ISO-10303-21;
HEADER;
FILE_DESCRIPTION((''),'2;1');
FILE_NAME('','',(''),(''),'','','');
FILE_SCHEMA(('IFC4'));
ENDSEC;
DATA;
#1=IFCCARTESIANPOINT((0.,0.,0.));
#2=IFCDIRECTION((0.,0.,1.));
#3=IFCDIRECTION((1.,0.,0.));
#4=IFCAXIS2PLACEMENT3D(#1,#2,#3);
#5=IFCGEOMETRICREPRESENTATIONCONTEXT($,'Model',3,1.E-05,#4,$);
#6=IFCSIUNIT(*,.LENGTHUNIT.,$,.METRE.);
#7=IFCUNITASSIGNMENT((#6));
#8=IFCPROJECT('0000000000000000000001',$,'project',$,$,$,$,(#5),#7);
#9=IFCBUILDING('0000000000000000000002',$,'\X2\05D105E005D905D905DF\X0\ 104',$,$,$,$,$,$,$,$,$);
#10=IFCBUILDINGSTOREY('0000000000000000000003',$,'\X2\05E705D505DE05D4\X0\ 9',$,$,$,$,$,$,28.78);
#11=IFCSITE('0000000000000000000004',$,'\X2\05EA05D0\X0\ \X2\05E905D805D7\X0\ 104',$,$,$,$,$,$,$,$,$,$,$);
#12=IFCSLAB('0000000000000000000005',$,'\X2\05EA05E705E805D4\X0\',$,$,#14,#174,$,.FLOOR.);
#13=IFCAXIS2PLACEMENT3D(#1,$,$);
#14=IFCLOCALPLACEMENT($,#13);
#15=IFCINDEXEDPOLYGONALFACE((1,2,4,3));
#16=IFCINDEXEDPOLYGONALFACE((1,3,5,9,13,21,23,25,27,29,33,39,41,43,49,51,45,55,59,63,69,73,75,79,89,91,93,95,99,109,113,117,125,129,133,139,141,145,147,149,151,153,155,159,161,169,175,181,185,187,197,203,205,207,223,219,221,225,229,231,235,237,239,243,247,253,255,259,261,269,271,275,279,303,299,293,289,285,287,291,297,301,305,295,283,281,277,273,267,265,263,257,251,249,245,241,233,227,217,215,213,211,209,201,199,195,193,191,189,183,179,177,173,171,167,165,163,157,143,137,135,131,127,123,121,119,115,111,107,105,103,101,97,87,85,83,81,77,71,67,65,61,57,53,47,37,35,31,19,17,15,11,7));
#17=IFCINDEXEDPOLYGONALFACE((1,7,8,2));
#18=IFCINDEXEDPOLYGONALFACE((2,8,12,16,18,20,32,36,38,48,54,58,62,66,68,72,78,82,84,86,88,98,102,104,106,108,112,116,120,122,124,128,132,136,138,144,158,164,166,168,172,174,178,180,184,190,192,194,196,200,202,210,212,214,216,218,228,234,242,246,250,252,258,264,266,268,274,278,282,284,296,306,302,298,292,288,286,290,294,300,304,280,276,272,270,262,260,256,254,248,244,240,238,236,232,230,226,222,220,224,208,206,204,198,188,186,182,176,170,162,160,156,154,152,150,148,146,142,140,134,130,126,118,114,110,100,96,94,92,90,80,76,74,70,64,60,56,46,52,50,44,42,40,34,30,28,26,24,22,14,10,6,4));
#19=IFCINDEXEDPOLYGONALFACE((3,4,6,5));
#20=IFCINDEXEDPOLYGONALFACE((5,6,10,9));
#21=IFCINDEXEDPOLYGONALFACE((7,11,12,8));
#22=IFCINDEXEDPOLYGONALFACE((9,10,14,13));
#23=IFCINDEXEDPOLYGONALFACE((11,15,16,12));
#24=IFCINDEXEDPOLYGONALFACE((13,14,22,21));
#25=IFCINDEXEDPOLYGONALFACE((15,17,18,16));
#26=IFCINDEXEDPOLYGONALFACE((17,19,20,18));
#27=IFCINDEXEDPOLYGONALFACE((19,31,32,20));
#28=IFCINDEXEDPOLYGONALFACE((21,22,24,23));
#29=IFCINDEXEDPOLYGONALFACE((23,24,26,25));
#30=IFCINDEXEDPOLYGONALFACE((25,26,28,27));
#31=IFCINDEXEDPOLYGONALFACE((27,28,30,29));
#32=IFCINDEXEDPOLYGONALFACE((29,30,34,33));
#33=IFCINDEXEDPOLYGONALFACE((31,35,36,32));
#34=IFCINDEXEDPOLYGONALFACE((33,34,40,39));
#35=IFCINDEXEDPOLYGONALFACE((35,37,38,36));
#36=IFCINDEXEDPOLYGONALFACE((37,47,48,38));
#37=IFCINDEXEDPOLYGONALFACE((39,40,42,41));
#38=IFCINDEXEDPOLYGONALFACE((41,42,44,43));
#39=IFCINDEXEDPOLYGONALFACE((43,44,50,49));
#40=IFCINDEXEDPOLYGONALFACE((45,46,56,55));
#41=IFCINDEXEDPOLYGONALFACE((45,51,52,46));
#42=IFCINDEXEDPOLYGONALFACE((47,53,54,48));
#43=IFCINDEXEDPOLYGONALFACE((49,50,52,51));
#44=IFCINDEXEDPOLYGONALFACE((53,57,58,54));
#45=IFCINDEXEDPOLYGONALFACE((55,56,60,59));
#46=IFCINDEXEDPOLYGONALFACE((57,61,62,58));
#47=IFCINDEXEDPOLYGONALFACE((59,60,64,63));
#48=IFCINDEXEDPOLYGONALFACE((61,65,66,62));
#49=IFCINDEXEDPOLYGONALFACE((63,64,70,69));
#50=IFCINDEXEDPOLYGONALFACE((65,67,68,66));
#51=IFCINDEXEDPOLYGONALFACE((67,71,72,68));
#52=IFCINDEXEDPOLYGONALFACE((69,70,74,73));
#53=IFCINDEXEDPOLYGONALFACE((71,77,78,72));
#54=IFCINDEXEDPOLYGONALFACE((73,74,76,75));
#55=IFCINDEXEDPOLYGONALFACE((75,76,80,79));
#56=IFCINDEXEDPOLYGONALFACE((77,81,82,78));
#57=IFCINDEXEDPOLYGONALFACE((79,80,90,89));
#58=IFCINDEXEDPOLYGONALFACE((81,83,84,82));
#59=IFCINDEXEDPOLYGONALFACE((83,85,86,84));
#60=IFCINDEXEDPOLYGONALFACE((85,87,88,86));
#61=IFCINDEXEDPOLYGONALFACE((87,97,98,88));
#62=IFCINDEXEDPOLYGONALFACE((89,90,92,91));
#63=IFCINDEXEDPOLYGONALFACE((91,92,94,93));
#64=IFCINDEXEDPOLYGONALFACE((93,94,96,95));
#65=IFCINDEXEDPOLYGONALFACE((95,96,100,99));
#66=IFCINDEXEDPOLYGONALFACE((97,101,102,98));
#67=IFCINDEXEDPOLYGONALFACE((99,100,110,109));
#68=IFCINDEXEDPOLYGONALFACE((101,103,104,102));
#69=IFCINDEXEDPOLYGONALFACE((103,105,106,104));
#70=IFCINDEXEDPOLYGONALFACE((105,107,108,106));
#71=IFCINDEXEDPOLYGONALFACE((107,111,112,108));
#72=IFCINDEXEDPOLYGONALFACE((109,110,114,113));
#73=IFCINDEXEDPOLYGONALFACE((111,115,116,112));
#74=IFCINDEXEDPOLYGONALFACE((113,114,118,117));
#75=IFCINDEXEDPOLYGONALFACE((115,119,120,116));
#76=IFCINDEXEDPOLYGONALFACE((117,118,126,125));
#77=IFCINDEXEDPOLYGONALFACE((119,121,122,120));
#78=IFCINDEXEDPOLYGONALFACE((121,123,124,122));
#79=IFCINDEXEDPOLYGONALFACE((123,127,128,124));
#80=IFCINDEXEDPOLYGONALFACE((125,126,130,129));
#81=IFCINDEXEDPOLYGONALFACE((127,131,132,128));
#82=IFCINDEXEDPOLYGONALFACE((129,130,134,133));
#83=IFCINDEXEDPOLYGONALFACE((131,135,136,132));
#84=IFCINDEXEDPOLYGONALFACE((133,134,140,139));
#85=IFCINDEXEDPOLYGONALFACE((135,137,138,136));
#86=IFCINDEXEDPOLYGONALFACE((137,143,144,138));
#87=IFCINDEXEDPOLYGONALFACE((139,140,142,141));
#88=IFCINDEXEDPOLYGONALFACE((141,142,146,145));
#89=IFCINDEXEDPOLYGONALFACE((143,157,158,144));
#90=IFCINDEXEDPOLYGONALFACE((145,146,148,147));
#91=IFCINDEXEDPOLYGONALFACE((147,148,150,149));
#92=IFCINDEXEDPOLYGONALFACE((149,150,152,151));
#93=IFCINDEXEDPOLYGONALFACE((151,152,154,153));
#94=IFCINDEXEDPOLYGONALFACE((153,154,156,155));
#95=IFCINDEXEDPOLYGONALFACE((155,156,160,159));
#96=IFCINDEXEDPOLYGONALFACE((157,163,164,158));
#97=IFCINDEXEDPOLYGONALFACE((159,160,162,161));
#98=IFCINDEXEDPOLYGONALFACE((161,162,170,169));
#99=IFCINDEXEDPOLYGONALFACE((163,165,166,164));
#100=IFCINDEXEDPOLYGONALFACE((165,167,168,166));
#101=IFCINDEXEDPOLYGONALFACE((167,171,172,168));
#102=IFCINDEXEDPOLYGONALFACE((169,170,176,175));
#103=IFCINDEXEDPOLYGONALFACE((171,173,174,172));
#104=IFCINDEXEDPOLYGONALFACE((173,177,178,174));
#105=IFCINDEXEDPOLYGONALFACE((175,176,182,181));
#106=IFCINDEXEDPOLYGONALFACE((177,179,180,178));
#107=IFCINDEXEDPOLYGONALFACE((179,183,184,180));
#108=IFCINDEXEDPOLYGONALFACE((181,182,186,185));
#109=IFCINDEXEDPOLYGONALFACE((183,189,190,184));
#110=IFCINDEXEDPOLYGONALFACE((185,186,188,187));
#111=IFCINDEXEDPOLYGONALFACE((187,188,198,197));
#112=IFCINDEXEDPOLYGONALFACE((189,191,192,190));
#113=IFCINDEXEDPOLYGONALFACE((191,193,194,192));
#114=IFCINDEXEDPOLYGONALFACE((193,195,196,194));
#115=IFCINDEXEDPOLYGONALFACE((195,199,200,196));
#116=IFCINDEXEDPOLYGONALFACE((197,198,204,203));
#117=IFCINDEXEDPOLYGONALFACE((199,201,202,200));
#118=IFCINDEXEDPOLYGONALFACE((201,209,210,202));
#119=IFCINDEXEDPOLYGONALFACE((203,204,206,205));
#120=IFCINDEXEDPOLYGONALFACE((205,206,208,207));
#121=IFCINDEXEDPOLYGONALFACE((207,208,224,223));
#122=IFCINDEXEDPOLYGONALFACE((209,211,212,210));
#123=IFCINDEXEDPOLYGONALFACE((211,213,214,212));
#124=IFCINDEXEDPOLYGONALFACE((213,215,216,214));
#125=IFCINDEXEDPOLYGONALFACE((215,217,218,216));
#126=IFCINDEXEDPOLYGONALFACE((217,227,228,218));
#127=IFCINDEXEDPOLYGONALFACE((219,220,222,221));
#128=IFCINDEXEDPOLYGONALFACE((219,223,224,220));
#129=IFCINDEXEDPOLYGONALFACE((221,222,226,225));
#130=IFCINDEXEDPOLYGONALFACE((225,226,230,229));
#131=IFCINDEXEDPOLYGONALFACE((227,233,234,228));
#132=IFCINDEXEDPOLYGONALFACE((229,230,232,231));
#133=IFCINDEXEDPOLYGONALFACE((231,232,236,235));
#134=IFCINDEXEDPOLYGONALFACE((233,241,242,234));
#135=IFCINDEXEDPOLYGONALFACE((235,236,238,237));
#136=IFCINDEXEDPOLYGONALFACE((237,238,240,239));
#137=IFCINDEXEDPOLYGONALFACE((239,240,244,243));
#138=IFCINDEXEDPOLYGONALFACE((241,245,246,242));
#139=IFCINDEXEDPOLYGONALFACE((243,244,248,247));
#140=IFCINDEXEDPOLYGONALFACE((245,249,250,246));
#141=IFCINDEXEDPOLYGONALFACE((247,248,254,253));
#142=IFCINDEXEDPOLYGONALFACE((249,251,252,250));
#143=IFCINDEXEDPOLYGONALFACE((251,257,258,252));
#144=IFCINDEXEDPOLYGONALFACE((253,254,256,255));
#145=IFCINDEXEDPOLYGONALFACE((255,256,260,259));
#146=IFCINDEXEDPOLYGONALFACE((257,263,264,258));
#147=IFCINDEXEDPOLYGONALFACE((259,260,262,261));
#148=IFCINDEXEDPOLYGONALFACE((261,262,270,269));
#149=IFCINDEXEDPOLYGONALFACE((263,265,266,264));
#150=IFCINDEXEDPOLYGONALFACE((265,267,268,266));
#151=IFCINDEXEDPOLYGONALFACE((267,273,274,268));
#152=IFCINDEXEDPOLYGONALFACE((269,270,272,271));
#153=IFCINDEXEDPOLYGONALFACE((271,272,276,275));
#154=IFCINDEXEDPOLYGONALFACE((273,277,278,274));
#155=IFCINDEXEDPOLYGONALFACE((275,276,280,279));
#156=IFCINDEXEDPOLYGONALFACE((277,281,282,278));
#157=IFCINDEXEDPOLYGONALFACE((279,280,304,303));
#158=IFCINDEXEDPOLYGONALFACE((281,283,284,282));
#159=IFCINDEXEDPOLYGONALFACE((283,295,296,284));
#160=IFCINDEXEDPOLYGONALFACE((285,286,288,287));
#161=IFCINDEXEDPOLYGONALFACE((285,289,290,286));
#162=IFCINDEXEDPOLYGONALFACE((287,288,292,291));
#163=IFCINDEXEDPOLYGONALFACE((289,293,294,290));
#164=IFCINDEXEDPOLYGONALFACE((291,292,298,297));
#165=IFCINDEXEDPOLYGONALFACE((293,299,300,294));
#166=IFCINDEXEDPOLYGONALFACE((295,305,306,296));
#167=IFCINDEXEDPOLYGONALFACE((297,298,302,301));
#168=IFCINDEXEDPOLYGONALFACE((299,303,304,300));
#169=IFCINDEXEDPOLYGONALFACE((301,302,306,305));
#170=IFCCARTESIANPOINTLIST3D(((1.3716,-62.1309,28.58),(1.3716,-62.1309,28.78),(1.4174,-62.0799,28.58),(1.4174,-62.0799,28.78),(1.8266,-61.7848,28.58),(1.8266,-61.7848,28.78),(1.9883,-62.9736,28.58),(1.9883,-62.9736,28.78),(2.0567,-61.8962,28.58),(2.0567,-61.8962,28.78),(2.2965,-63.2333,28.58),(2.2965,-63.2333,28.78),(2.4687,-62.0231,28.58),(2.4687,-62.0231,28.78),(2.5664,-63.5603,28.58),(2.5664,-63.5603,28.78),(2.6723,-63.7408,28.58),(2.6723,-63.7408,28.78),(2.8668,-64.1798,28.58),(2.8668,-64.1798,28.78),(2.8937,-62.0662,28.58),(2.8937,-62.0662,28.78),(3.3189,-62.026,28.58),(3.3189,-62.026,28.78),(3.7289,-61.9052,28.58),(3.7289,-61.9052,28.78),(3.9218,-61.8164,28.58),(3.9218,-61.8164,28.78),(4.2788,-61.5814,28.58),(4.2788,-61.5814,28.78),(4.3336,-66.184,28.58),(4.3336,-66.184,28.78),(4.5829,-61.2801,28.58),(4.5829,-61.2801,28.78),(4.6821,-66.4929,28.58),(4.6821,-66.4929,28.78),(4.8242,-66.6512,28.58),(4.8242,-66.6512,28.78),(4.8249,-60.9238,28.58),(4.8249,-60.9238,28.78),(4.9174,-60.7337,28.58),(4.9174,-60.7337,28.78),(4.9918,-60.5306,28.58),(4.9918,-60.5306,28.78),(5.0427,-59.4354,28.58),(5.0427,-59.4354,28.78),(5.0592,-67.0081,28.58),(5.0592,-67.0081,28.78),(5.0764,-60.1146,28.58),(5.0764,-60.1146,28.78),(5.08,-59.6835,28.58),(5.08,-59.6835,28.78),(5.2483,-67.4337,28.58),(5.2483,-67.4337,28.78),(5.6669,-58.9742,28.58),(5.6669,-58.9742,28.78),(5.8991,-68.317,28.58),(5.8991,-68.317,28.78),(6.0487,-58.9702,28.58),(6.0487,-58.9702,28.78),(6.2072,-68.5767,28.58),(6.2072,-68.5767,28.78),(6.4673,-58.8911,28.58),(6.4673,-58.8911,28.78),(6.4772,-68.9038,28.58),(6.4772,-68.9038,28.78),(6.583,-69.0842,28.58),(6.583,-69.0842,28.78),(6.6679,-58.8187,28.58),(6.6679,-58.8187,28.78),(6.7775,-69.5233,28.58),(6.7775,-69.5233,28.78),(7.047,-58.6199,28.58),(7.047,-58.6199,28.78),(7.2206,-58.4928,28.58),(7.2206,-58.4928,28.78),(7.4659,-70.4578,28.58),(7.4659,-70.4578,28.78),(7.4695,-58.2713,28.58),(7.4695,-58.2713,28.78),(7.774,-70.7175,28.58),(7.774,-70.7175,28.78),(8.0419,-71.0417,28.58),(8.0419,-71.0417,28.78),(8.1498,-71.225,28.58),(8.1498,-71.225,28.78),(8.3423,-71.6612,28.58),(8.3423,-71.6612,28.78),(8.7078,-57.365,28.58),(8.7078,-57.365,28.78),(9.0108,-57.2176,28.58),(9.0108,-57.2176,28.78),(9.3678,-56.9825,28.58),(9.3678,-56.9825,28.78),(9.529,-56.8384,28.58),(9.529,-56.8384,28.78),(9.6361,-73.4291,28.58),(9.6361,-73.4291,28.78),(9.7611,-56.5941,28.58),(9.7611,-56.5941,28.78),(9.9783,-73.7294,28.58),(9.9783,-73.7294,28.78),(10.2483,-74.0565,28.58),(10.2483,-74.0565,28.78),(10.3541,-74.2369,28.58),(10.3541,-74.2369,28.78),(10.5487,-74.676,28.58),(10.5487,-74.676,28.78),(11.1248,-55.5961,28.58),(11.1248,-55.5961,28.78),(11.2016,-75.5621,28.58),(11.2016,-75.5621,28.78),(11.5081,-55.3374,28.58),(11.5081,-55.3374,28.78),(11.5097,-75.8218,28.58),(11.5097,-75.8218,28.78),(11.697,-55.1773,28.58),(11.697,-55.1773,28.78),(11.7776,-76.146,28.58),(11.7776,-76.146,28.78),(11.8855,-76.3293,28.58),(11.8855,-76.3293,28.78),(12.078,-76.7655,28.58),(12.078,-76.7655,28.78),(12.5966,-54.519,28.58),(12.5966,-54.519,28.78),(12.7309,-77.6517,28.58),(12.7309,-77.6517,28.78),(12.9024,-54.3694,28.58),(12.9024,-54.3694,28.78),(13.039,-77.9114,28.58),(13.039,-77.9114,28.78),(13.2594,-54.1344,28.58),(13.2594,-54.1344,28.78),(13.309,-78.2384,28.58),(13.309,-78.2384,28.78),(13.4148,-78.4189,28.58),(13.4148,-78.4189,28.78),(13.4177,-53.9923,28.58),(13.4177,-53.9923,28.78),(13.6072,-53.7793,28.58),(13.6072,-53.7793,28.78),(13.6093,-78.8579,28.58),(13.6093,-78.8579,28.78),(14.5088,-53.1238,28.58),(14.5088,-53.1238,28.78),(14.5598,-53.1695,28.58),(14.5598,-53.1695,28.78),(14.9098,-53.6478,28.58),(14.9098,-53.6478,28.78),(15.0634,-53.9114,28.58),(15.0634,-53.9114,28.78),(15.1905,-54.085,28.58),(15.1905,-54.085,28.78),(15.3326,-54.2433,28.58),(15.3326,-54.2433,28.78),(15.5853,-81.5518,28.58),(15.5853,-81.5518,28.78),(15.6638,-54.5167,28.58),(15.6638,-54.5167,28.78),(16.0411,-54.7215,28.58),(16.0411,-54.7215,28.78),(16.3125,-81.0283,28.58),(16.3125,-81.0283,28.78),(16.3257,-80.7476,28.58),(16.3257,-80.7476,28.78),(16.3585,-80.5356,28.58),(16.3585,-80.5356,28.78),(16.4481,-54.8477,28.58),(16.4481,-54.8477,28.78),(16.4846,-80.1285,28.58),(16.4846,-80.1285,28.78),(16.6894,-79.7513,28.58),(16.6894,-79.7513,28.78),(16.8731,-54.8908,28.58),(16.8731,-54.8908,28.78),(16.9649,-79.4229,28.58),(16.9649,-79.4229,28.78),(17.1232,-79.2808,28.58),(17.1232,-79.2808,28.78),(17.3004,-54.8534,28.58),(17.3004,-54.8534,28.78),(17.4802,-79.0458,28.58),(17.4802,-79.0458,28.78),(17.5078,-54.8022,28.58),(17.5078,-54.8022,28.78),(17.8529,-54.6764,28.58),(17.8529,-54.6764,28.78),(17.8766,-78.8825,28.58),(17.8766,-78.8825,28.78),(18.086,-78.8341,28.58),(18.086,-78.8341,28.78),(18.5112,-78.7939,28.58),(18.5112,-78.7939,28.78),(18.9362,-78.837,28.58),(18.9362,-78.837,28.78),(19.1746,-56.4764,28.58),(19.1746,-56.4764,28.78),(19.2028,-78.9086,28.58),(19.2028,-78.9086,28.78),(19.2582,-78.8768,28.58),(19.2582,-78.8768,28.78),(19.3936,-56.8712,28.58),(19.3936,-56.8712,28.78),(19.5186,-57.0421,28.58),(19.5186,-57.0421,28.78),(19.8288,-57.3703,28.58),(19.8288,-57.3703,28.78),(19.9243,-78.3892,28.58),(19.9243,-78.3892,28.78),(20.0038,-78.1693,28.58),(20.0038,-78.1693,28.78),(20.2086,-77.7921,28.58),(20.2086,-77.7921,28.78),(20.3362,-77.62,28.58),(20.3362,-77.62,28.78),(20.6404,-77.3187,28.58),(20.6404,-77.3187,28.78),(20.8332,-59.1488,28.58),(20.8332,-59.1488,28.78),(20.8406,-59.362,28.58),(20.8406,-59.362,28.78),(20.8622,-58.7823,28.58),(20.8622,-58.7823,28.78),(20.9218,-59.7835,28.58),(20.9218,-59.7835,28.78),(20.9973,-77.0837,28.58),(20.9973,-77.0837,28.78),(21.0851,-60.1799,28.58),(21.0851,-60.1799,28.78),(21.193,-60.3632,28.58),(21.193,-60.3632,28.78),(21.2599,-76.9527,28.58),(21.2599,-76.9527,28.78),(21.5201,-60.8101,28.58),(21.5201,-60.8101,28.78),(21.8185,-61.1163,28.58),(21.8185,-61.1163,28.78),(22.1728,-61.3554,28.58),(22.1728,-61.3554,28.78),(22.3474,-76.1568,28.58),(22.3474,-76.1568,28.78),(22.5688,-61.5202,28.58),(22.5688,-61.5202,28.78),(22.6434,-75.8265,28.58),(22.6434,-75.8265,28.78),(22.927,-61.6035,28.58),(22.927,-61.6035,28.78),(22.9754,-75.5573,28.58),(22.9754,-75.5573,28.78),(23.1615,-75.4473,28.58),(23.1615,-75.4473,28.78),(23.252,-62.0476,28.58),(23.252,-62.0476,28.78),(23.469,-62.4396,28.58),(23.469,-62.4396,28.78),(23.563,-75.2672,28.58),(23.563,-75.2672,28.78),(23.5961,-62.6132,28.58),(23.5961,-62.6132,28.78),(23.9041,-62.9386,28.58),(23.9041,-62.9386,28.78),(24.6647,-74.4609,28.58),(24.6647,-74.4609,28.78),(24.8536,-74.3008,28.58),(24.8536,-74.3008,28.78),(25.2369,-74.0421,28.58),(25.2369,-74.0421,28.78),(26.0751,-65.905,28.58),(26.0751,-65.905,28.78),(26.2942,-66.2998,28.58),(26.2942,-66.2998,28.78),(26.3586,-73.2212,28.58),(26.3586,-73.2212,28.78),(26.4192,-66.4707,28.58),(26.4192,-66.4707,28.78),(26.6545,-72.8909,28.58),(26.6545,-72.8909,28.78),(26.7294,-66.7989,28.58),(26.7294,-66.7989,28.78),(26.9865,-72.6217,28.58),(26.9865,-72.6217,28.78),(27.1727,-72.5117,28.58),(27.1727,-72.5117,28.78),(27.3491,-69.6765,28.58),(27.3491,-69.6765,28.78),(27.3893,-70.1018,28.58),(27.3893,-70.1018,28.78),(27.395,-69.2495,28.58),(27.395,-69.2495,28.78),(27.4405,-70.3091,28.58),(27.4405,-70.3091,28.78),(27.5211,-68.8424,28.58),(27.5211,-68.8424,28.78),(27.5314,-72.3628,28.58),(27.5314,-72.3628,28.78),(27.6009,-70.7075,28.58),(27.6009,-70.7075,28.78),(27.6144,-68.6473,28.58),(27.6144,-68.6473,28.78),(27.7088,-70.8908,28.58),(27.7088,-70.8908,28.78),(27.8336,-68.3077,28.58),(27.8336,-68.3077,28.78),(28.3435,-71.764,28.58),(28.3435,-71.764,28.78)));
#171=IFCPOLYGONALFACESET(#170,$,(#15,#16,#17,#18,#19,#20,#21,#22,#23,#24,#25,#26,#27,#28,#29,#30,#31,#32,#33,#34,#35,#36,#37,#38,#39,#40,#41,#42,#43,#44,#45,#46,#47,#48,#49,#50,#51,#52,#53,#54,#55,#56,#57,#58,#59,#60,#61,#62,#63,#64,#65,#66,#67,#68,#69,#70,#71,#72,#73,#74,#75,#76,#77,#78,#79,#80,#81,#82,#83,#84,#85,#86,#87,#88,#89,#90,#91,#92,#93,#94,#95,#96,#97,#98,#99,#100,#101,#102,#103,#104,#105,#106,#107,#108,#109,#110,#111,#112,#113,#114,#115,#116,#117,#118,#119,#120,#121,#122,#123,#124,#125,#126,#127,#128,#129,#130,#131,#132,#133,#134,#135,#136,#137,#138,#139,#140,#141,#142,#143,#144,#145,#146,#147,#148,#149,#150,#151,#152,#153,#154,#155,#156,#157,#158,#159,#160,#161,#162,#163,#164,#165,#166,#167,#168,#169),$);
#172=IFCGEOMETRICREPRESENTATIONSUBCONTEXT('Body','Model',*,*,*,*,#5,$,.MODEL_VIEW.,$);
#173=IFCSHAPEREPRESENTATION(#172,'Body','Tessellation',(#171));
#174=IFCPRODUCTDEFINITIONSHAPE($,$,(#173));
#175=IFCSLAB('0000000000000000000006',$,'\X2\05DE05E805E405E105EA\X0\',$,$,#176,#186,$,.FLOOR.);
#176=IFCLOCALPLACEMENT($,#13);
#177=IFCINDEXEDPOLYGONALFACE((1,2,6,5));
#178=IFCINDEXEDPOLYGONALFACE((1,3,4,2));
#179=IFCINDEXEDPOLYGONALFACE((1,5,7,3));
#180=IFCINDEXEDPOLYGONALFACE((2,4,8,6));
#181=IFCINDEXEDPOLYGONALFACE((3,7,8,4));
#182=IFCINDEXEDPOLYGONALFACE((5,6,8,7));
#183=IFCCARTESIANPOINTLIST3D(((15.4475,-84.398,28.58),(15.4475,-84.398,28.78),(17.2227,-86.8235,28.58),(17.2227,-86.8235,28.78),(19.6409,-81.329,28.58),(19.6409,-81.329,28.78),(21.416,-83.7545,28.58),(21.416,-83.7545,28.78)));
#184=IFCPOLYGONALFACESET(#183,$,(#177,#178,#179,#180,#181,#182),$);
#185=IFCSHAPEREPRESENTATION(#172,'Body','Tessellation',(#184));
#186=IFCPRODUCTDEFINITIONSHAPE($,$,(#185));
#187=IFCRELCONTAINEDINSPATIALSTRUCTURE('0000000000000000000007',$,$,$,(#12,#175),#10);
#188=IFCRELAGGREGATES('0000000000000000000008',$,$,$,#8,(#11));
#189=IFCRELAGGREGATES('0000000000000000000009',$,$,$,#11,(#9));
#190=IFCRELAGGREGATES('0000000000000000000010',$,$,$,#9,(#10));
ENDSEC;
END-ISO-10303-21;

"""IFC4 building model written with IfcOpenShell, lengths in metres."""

from ifc_helpers import new_model, si_unit, frame, origin_with_axes, context, subcontext, project, spatial, polyline, outline, extrude, element, save


model = new_model("IFC4")

# Units and contexts
model_context = context("Model", 3, precision=1e-05, world=origin_with_axes())
body_context = subcontext(model_context, "Body", "Model", "MODEL_VIEW")
ifc_project = project(units=[si_unit("LENGTHUNIT", "METRE")], contexts=[model_context])

# Site, building, storey
site = spatial("IfcSite", under=ifc_project, Name="תא שטח 104")
building = spatial("IfcBuilding", under=site, Name="בניין 104")
storey = spatial("IfcBuildingStorey", under=building, Name="קומה 9", Elevation=28.78)

# Slabs
element("IfcSlab", 1, inside=storey, Name="תקרה", PredefinedType="FLOOR", context=body_context, shape_type="SweptSolid", body=[
    extrude(outline(polyline([(5.6669, -58.9742), (5.0427, -59.4354), (5.08, -59.6835), (5.0764, -60.1146), (4.9918, -60.5306), (4.9174, -60.7337), (4.8249, -60.9238), (4.5829, -61.2801), (4.2788, -61.5814), (3.9218, -61.8164), (3.7289, -61.9052), (3.3189, -62.026), (2.8937, -62.0662), (2.4687, -62.0231), (2.0567, -61.8962), (1.8266, -61.7848), (1.4174, -62.0799), (1.3716, -62.1309), (1.9883, -62.9736), (2.2965, -63.2333), (2.5664, -63.5603), (2.6723, -63.7408), (2.8668, -64.1798), (4.3336, -66.184), (4.6821, -66.4929), (4.8242, -66.6512), (5.0592, -67.0081), (5.2483, -67.4337), (5.8991, -68.317), (6.2072, -68.5767), (6.4772, -68.9038), (6.583, -69.0842), (6.7775, -69.5233), (7.4659, -70.4578), (7.774, -70.7175), (8.0419, -71.0417), (8.1498, -71.225), (8.3423, -71.6612), (9.6361, -73.4291), (9.9783, -73.7294), (10.2483, -74.0565), (10.3541, -74.2369), (10.5487, -74.676), (11.2016, -75.5621), (11.5097, -75.8218), (11.7776, -76.146), (11.8855, -76.3293), (12.078, -76.7655), (12.7309, -77.6517), (13.039, -77.9114), (13.309, -78.2384), (13.4148, -78.4189), (13.6093, -78.8579), (15.5853, -81.5518), (16.3125, -81.0283), (16.3257, -80.7476), (16.3585, -80.5356), (16.4846, -80.1285), (16.6894, -79.7513), (16.9649, -79.4229), (17.1232, -79.2808), (17.4802, -79.0458), (17.8766, -78.8825), (18.086, -78.8341), (18.5112, -78.7939), (18.9362, -78.837), (19.2028, -78.9086), (19.2582, -78.8768), (19.9243, -78.3892), (20.0038, -78.1693), (20.2086, -77.7921), (20.3362, -77.62), (20.6404, -77.3187), (20.9973, -77.0837), (21.2599, -76.9527), (22.3474, -76.1568), (22.6434, -75.8265), (22.9754, -75.5573), (23.1615, -75.4473), (23.563, -75.2672), (24.6647, -74.4609), (24.8536, -74.3008), (25.2369, -74.0421), (26.3586, -73.2212), (26.6545, -72.8909), (26.9865, -72.6217), (27.1727, -72.5117), (27.5314, -72.3628), (28.3435, -71.764), (27.7088, -70.8908), (27.6009, -70.7075), (27.4405, -70.3091), (27.3893, -70.1018), (27.3491, -69.6765), (27.395, -69.2495), (27.5211, -68.8424), (27.6144, -68.6473), (27.8336, -68.3077), (26.7294, -66.7989), (26.4192, -66.4707), (26.2942, -66.2998), (26.0751, -65.905), (23.9041, -62.9386), (23.5961, -62.6132), (23.469, -62.4396), (23.252, -62.0476), (22.927, -61.6035), (22.5688, -61.5202), (22.1728, -61.3554), (21.8185, -61.1163), (21.5201, -60.8101), (21.193, -60.3632), (21.0851, -60.1799), (20.9218, -59.7835), (20.8406, -59.362), (20.8332, -59.1488), (20.8622, -58.7823), (19.8288, -57.3703), (19.5186, -57.0421), (19.3936, -56.8712), (19.1746, -56.4764), (17.8529, -54.6764), (17.5078, -54.8022), (17.3004, -54.8534), (16.8731, -54.8908), (16.4481, -54.8477), (16.0411, -54.7215), (15.6638, -54.5167), (15.3326, -54.2433), (15.1905, -54.085), (15.0634, -53.9114), (14.9098, -53.6478), (14.5598, -53.1695), (14.5088, -53.1238), (13.6072, -53.7793), (13.4177, -53.9923), (13.2594, -54.1344), (12.9024, -54.3694), (12.5966, -54.519), (11.697, -55.1773), (11.5081, -55.3374), (11.1248, -55.5961), (9.7611, -56.5941), (9.529, -56.8384), (9.3678, -56.9825), (9.0108, -57.2176), (8.7078, -57.365), (7.4695, -58.2713), (7.2206, -58.4928), (7.047, -58.6199), (6.6679, -58.8187), (6.4673, -58.8911), (6.0487, -58.9702), (5.6669, -58.9742)])), frame((0.0, 0.0, 28.58)), (0.0, 0.0, 1.0), 0.2),
])
element("IfcSlab", 2, inside=storey, Name="מרפסת", PredefinedType="FLOOR", context=body_context, shape_type="SweptSolid", body=[
    extrude(outline(polyline([(19.6409, -81.329), (21.416, -83.7545), (17.2227, -86.8235), (15.4475, -84.398), (19.6409, -81.329)])), frame((0.0, 0.0, 28.58)), (0.0, 0.0, 1.0), 0.2),
])

save(model, "model.ifc")
